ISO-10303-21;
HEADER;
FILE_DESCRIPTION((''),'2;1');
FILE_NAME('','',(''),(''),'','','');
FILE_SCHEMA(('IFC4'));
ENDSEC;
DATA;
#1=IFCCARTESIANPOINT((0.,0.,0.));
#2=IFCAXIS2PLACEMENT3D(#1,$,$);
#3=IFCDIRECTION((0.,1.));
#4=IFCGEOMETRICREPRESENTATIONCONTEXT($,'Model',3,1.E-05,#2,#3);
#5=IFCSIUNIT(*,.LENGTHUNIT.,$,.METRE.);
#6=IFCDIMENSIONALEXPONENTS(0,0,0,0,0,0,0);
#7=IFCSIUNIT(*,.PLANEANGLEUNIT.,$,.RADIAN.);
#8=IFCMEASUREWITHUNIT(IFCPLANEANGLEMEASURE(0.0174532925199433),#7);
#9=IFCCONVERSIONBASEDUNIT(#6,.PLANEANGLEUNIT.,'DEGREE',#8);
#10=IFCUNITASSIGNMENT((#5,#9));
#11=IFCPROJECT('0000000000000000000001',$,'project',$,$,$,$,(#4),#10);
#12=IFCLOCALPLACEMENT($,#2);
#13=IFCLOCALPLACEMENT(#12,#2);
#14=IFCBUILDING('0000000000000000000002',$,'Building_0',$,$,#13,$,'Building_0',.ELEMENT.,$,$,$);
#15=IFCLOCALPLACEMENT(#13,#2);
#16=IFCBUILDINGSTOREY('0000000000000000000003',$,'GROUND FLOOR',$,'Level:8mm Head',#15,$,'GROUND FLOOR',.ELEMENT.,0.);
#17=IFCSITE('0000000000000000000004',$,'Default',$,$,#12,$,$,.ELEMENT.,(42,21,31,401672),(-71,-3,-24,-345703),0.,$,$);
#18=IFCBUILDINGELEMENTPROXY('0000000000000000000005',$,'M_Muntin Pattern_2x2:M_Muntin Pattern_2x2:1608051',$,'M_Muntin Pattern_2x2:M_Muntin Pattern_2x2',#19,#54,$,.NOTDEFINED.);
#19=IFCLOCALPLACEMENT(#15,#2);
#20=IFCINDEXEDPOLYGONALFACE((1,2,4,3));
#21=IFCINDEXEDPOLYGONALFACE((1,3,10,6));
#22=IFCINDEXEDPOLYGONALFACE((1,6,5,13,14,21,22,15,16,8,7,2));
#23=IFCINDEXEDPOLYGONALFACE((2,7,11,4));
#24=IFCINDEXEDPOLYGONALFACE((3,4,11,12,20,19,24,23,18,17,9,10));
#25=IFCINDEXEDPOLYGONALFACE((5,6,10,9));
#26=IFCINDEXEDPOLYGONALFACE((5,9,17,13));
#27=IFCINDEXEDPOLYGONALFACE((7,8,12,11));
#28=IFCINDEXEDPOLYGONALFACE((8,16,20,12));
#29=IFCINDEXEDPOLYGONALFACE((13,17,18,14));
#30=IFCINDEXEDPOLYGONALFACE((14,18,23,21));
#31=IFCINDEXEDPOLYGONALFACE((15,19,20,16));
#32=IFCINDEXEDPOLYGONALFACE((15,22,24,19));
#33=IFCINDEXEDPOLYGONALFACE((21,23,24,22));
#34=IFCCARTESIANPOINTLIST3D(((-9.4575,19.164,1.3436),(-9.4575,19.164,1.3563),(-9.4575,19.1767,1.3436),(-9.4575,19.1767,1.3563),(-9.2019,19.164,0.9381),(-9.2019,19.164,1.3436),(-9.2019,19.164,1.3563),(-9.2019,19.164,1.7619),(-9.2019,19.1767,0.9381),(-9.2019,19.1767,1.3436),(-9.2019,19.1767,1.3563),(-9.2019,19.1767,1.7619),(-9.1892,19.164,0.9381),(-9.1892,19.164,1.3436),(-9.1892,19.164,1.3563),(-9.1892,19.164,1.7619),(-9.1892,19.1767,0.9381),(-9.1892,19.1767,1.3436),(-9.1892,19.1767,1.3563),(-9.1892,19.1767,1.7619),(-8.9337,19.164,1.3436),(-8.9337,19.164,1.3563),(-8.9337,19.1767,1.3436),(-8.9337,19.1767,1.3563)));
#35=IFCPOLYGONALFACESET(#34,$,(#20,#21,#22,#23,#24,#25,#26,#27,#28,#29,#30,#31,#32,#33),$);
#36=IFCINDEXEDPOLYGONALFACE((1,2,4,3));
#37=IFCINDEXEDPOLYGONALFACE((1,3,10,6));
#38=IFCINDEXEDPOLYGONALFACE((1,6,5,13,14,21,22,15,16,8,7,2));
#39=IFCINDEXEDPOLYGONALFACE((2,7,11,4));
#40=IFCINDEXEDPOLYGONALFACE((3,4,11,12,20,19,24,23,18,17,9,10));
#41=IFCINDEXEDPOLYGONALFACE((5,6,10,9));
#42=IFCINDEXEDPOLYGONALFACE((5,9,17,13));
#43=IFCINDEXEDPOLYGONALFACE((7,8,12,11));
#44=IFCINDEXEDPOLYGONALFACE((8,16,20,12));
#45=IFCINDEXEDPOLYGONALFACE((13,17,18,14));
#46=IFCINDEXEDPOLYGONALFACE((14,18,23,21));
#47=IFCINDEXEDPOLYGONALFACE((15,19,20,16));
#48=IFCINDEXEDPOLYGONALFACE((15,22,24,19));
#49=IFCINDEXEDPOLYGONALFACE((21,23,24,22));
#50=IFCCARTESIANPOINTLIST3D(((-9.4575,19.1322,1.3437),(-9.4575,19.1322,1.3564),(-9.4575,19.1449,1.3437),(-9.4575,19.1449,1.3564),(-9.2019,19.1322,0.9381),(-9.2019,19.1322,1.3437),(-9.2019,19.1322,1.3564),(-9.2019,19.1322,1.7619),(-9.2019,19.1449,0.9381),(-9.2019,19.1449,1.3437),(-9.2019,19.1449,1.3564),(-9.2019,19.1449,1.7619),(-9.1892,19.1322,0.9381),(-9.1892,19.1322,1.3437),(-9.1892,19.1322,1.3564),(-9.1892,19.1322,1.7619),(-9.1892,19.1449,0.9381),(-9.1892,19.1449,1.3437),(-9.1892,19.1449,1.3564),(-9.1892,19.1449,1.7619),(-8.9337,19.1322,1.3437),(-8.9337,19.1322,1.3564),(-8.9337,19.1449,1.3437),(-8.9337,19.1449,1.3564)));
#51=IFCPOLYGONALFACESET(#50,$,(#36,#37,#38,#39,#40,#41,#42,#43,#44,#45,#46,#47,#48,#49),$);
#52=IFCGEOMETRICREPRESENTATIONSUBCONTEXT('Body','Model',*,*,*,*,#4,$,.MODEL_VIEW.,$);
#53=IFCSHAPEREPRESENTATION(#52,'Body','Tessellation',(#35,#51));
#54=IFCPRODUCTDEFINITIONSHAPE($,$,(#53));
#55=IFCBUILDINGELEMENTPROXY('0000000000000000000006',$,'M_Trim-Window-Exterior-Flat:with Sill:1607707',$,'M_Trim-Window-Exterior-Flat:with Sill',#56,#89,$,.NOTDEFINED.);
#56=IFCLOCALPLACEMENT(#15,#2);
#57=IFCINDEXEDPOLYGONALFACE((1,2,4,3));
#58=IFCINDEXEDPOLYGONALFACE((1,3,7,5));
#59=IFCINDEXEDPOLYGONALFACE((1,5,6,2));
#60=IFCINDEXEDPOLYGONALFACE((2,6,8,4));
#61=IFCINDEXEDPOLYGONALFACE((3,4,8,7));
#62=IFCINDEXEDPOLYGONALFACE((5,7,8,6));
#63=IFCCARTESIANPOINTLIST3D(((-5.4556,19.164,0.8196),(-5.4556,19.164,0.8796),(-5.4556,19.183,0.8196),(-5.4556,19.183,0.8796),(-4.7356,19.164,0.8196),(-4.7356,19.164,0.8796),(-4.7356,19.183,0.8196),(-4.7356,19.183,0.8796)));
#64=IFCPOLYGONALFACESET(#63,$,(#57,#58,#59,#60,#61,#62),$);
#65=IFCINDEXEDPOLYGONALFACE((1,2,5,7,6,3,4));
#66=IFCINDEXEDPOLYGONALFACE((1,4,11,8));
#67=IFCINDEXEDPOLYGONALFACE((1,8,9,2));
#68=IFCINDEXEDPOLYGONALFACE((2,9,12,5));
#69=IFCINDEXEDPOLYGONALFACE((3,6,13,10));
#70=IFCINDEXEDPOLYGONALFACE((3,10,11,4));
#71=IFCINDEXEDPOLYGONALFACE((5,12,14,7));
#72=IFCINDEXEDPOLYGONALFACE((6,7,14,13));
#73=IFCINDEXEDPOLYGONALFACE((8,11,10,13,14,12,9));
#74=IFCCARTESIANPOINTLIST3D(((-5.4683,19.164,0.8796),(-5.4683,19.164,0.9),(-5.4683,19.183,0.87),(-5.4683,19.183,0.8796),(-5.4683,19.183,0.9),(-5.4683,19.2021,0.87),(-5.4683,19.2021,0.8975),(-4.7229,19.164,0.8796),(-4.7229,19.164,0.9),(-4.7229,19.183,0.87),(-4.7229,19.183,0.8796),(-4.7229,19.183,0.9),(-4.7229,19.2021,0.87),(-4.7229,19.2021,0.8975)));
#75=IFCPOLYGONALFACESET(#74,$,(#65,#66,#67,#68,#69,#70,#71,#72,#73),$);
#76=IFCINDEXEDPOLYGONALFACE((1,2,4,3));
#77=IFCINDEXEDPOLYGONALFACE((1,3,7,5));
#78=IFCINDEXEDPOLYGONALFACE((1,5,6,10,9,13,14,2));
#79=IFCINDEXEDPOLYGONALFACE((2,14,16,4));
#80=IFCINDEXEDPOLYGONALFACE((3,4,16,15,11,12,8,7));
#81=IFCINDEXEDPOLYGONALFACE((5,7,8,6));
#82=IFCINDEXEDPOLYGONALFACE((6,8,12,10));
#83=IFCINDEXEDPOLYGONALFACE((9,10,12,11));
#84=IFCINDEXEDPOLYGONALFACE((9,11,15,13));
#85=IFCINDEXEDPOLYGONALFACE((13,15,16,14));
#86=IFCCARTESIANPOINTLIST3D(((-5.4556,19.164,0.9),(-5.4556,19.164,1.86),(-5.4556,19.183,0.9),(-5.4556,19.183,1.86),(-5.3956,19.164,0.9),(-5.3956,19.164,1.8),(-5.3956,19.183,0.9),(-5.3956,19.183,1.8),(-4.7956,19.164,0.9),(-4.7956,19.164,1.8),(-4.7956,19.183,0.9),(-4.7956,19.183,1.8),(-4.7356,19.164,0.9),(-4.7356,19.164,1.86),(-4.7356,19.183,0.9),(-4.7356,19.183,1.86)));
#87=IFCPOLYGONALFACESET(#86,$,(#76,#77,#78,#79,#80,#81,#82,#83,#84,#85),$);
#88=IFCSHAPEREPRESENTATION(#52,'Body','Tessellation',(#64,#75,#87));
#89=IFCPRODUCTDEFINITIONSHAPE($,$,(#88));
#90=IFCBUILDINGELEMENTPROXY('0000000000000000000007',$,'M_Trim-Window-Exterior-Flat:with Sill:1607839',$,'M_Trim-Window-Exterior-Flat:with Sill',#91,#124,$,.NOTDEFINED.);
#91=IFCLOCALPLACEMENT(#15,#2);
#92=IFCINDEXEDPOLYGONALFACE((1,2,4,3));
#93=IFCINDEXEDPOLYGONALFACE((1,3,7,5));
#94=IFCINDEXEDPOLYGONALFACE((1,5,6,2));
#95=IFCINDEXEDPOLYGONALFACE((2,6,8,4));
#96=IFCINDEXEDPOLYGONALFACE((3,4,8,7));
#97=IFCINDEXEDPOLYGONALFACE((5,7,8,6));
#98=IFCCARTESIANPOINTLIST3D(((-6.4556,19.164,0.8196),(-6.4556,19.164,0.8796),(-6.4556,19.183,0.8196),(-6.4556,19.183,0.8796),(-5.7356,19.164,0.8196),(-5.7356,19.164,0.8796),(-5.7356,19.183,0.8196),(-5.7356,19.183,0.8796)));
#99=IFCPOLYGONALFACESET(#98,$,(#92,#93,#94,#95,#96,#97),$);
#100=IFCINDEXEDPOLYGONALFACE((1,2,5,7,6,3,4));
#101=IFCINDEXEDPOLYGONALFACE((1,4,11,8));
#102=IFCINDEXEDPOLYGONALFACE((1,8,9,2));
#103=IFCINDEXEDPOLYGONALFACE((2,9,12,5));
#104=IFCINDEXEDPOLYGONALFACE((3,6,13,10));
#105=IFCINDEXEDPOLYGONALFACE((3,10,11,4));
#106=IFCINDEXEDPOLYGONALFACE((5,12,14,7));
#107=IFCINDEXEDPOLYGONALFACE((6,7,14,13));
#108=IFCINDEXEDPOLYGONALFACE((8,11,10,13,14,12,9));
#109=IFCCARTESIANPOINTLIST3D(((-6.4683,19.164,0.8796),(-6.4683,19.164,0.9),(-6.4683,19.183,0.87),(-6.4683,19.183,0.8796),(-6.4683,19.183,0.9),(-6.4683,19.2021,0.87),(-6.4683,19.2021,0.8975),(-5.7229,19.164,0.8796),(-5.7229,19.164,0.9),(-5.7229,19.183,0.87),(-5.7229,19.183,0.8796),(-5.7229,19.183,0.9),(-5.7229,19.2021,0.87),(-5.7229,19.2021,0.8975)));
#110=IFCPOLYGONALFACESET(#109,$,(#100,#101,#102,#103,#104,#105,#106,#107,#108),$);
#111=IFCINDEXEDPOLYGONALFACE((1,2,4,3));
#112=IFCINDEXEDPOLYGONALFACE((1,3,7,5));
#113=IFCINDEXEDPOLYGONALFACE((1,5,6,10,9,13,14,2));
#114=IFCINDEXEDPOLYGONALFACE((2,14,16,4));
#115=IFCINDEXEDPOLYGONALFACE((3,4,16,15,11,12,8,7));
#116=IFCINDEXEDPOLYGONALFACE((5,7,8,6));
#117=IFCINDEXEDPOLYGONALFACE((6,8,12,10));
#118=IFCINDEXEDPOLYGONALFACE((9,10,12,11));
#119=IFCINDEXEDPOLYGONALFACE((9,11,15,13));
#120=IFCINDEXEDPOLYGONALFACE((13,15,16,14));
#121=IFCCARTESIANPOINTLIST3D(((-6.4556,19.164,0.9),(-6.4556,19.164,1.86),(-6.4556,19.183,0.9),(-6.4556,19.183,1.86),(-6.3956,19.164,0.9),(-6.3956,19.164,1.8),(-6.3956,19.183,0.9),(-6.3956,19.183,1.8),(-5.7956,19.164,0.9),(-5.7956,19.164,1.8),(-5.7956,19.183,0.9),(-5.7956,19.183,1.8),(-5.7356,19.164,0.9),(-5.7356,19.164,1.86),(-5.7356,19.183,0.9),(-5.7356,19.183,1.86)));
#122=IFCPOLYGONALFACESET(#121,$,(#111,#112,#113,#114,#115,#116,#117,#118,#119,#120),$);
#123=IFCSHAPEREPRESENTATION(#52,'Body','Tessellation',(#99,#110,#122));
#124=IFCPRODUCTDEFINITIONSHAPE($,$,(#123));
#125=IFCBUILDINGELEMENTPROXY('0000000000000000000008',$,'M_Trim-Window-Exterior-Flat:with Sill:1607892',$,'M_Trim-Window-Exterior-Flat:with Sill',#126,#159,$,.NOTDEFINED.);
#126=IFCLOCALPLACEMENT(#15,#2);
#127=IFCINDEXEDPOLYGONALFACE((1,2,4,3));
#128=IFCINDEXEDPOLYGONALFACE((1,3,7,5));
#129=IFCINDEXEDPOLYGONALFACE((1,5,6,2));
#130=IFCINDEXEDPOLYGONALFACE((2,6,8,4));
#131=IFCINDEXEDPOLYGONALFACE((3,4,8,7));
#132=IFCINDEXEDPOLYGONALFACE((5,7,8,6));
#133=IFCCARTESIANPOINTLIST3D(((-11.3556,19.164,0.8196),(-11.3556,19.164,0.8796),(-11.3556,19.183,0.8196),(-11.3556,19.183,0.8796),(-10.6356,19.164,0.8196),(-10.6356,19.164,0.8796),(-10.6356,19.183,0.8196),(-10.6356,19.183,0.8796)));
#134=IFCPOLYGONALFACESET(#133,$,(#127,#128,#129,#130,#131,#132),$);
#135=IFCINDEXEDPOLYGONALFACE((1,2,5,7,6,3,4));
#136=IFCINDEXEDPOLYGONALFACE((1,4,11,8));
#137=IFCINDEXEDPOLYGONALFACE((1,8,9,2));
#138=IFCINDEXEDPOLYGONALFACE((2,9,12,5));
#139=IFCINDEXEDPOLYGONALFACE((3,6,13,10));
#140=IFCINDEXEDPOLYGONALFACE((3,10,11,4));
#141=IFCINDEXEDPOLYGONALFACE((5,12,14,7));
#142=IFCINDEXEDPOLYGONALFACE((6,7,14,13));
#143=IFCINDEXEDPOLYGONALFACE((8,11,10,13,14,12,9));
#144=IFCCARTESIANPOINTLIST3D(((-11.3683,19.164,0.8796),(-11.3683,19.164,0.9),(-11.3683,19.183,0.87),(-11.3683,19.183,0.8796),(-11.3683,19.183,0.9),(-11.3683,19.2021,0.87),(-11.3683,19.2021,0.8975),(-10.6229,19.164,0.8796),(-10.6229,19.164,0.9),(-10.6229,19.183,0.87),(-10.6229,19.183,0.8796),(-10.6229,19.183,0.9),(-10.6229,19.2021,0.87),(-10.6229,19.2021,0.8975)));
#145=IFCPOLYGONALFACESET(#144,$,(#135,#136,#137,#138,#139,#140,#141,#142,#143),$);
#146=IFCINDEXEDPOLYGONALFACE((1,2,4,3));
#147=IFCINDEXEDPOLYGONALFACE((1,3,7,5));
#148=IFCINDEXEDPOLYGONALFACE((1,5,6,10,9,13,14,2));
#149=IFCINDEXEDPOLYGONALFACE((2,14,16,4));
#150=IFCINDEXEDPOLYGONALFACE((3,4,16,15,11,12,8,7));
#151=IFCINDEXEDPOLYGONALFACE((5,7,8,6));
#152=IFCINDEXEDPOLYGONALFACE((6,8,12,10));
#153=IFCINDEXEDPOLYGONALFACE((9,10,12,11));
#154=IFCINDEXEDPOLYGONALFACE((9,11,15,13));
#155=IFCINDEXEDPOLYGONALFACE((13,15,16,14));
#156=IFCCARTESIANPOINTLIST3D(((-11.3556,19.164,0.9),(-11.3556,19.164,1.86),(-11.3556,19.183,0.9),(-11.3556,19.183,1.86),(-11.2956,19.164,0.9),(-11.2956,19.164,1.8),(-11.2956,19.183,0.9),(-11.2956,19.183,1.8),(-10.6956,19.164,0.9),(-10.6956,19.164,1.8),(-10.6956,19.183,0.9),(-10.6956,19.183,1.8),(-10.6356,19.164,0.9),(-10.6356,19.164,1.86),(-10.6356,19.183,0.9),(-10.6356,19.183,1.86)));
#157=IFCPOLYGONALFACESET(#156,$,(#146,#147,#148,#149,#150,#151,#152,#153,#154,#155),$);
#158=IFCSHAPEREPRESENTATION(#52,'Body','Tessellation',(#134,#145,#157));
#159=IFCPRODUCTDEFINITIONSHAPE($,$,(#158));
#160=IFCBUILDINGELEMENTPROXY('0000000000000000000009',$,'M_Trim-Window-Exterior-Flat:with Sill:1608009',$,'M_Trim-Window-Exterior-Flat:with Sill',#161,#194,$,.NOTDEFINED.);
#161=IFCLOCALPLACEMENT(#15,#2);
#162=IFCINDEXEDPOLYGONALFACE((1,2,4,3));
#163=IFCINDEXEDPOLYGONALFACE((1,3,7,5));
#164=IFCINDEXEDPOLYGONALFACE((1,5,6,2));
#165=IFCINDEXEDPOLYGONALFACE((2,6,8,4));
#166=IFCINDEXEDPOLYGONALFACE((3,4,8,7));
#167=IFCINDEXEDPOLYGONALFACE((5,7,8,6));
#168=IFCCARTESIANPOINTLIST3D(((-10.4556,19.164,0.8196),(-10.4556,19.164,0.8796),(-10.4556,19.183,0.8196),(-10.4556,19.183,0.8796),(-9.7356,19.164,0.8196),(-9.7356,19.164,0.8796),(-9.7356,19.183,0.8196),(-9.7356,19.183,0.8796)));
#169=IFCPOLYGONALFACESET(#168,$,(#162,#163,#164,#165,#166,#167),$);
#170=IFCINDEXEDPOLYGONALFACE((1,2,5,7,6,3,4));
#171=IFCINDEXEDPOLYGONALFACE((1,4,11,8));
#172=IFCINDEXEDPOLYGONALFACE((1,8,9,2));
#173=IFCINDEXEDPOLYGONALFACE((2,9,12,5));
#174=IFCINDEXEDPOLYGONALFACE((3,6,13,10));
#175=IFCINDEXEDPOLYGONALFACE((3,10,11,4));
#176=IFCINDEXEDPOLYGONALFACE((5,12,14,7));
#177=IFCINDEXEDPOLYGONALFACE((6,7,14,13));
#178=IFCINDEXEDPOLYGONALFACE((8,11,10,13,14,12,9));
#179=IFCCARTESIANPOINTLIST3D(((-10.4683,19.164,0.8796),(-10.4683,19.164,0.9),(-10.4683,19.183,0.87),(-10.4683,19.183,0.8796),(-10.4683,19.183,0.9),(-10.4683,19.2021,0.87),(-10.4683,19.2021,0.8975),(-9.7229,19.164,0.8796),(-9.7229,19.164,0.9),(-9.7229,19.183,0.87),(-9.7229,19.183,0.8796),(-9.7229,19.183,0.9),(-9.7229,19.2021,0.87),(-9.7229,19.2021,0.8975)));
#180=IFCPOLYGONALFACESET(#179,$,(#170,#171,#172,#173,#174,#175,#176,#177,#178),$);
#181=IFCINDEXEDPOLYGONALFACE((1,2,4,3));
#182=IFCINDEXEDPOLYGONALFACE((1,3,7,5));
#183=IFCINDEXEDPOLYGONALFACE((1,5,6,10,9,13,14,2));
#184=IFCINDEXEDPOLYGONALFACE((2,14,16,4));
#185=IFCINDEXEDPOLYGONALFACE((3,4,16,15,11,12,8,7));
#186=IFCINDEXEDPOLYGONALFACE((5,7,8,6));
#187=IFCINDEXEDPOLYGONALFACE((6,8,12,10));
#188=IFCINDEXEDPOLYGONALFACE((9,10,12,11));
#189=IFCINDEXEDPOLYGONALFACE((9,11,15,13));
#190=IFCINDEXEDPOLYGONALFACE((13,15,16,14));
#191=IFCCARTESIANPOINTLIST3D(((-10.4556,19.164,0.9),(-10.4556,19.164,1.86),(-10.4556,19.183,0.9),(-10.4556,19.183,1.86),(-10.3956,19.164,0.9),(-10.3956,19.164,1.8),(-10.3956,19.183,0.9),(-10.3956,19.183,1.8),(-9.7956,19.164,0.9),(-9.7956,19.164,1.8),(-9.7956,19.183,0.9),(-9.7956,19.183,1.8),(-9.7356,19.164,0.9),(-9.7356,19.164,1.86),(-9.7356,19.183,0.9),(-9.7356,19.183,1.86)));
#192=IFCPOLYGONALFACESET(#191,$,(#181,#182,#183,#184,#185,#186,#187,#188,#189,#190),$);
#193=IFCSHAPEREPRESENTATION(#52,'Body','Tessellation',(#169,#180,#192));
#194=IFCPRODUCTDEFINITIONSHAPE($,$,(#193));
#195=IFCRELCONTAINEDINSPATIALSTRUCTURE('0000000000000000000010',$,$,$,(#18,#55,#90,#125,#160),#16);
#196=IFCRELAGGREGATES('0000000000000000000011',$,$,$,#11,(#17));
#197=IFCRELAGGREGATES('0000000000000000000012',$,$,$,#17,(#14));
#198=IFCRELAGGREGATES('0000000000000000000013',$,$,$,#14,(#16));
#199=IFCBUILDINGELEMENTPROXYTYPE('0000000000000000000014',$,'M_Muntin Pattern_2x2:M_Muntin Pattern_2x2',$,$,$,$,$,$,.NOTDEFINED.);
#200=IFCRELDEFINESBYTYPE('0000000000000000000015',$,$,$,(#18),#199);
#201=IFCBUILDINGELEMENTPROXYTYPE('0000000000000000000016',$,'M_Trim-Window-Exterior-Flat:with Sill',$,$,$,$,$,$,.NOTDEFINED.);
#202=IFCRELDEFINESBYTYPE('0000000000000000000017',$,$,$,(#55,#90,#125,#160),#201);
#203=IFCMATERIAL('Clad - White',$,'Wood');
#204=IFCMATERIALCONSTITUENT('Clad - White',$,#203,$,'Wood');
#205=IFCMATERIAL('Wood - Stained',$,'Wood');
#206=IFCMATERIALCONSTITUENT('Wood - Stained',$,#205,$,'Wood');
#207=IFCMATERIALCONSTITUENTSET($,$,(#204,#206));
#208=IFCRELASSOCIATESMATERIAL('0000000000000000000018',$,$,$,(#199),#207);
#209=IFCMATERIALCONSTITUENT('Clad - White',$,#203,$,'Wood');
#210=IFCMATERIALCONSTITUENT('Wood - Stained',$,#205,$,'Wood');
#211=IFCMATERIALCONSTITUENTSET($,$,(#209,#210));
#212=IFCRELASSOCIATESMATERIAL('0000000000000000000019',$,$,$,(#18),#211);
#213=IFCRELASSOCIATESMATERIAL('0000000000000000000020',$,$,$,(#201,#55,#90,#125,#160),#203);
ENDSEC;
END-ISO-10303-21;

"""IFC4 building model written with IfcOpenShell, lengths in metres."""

from ifc_helpers import new_model, entity, si_unit, converted_unit, direction, frame, origin, place, context, subcontext, project, spatial, indexed_curve, outline, extrude, source, transform, mapped, material, constituent, constituent_set, type_object, type_shapes, element, save


model = new_model("IFC4")

# Units and contexts
model_context = context("Model", 3, precision=1e-05, world=origin(), true_north=direction((0.0, 1.0)))
body_context = subcontext(model_context, "Body", "Model", "MODEL_VIEW")
ifc_project = project(units=[si_unit("LENGTHUNIT", "METRE"), converted_unit("PLANEANGLEUNIT", "DEGREE", entity("IfcPlaneAngleMeasure", 0.0174532925199433), si_unit("PLANEANGLEUNIT", "RADIAN"), dimensions=[0, 0, 0, 0, 0, 0, 0])], contexts=[model_context])

# Site, building, storey
site_placement = place(None, origin())
site = spatial("IfcSite", under=ifc_project, at=site_placement, Name="Default", CompositionType="ELEMENT", RefLatitude=(42, 21, 31, 401672), RefLongitude=(-71, -3, -24, -345703), RefElevation=0.0)
building_placement = place(site_placement, origin())
building = spatial("IfcBuilding", under=site, at=building_placement, Name="Building_0", LongName="Building_0", CompositionType="ELEMENT")
storey_placement = place(building_placement, origin())
storey = spatial("IfcBuildingStorey", under=building, at=storey_placement, Name="GROUND FLOOR", ObjectType="Level:8mm Head", LongName="GROUND FLOOR", CompositionType="ELEMENT", Elevation=0.0)

# Shared definitions
ifc_material_1 = material(Name="Clad - White", Category="Wood")

# Building element proxies
ifc_material_2 = material(Name="Wood - Stained", Category="Wood")
ifc_constituent_1 = constituent(ifc_material_1, Name="Clad - White", Category="Wood")
ifc_constituent_2 = constituent(ifc_material_2, Name="Wood - Stained", Category="Wood")
ifc_constituent_set_1 = constituent_set(constituents=[ifc_constituent_1, ifc_constituent_2])
building_element_proxy_type_1 = type_object("IfcBuildingElementProxyType", Name="M_Muntin Pattern_2x2:M_Muntin Pattern_2x2", PredefinedType="NOTDEFINED", material=ifc_constituent_set_1)
shared_shape_1 = source(origin(), body_context, "Body", "SweptSolid", [
    extrude(outline(indexed_curve([(0.0064, -0.0064), (0.4119, -0.0064), (0.4119, 0.0063), (0.0064, 0.0063), (0.0064, 0.2619), (-0.0063, 0.2619), (-0.0063, 0.0063), (-0.4119, 0.0063), (-0.4119, -0.0064), (-0.0063, -0.0064), (-0.0063, -0.2619), (0.0064, -0.2619), (0.0064, -0.0064)], self_intersect=False)), frame((0.0, -0.0222, 0.4119), z_axis=(0.0, 1.0, 0.0), x_axis=(0.0, 0.0, 1.0)), (0.0, 0.0, 1.0), 0.0127),
    extrude(outline(indexed_curve([(0.0064, -0.0064), (0.4119, -0.0064), (0.4119, 0.0063), (0.0064, 0.0063), (0.0064, 0.2619), (-0.0063, 0.2619), (-0.0063, 0.0063), (-0.4119, 0.0063), (-0.4119, -0.0064), (-0.0063, -0.0064), (-0.0063, -0.2619), (0.0064, -0.2619), (0.0064, -0.0064)], self_intersect=False)), frame((0.0, 0.0095, 0.4119), z_axis=(0.0, 1.0, 0.0), x_axis=(0.0, 0.0, 1.0)), (0.0, 0.0, 1.0), 0.0127),
])
type_shapes(building_element_proxy_type_1, [shared_shape_1])
ifc_constituent_3 = constituent(ifc_material_1, Name="Clad - White", Category="Wood")
ifc_constituent_4 = constituent(ifc_material_2, Name="Wood - Stained", Category="Wood")
ifc_constituent_set_2 = constituent_set(constituents=[ifc_constituent_3, ifc_constituent_4])
proxy_1_placement = place(storey_placement, frame((-9.1956, 19.1545, 0.9381), z_axis=(0.0, 0.0, 1.0), x_axis=(-1.0, 0.0, 0.0)))
element("IfcBuildingElementProxy", 1, at=proxy_1_placement, inside=storey, type_object=building_element_proxy_type_1, material=ifc_constituent_set_2, Name="M_Muntin Pattern_2x2:M_Muntin Pattern_2x2:1608051", ObjectType="M_Muntin Pattern_2x2:M_Muntin Pattern_2x2", PredefinedType="NOTDEFINED", context=body_context, shape_type="MappedRepresentation", body=[
    mapped(shared_shape_1, transform((0.0, 0.0, 0.0), scale=1.0)),
])
building_element_proxy_type_2 = type_object("IfcBuildingElementProxyType", Name="M_Trim-Window-Exterior-Flat:with Sill", PredefinedType="NOTDEFINED", material=ifc_material_1)
shared_shape_2 = source(origin(), body_context, "Body", "SweptSolid", [
    extrude(outline(indexed_curve([(-0.36, -0.03), (0.36, -0.03), (0.36, 0.03), (-0.36, 0.03), (-0.36, -0.03)], self_intersect=False)), frame((0.0, -0.9504, 0.0), z_axis=(0.0, 0.0, 1.0), x_axis=(-1.0, 0.0, 0.0)), (0.0, 0.0, 1.0), 0.0191),
    extrude(outline(indexed_curve([(-0.019, -0.0152), (0.0, -0.0152), (0.0, -0.0057), (0.019, -0.0057), (0.019, 0.0148), (0.0, 0.0148), (-0.019, 0.0123), (-0.019, -0.0152)], self_intersect=False)), frame((-0.3727, -0.9148, 0.019), z_axis=(1.0, 0.0, 0.0), x_axis=(0.0, 0.0, -1.0)), (0.0, 0.0, 1.0), 0.7454),
    extrude(outline(indexed_curve([(-0.495, -0.36), (0.465, -0.36), (0.465, -0.3), (-0.435, -0.3), (-0.435, 0.3), (0.465, 0.3), (0.465, 0.36), (-0.495, 0.36), (-0.495, -0.36)], self_intersect=False)), frame((0.0, -0.435, 0.0), z_axis=(0.0, 0.0, 1.0), x_axis=(0.0, -1.0, 0.0)), (0.0, 0.0, 1.0), 0.0191),
])
type_shapes(building_element_proxy_type_2, [shared_shape_2])
for number, where, z_axis, x_axis, name in (
    (2, (-5.0956, 19.164, 1.8), (0.0, 1.0, 0.0), (-1.0, 0.0, 0.0), "M_Trim-Window-Exterior-Flat:with Sill:1607707"),
    (3, (-6.0956, 19.164, 1.8), (0.0, 1.0, 0.0), (-1.0, 0.0, 0.0), "M_Trim-Window-Exterior-Flat:with Sill:1607839"),
    (4, (-10.9956, 19.164, 1.8), (0.0, 1.0, 0.0), (-1.0, 0.0, 0.0), "M_Trim-Window-Exterior-Flat:with Sill:1607892"),
    (5, (-10.0956, 19.164, 1.8), (0.0, 1.0, 0.0), (-1.0, 0.0, 0.0), "M_Trim-Window-Exterior-Flat:with Sill:1608009"),
):
    element("IfcBuildingElementProxy", number, at=place(storey_placement, frame(where, z_axis=z_axis, x_axis=x_axis)), inside=storey, type_object=building_element_proxy_type_2, material=ifc_material_1, Name=name, ObjectType="M_Trim-Window-Exterior-Flat:with Sill", PredefinedType="NOTDEFINED", context=body_context, shape_type="MappedRepresentation", body=[
        mapped(shared_shape_2, transform((0.0, 0.0, 0.0), scale=1.0)),
    ])

save(model, "model.ifc")
